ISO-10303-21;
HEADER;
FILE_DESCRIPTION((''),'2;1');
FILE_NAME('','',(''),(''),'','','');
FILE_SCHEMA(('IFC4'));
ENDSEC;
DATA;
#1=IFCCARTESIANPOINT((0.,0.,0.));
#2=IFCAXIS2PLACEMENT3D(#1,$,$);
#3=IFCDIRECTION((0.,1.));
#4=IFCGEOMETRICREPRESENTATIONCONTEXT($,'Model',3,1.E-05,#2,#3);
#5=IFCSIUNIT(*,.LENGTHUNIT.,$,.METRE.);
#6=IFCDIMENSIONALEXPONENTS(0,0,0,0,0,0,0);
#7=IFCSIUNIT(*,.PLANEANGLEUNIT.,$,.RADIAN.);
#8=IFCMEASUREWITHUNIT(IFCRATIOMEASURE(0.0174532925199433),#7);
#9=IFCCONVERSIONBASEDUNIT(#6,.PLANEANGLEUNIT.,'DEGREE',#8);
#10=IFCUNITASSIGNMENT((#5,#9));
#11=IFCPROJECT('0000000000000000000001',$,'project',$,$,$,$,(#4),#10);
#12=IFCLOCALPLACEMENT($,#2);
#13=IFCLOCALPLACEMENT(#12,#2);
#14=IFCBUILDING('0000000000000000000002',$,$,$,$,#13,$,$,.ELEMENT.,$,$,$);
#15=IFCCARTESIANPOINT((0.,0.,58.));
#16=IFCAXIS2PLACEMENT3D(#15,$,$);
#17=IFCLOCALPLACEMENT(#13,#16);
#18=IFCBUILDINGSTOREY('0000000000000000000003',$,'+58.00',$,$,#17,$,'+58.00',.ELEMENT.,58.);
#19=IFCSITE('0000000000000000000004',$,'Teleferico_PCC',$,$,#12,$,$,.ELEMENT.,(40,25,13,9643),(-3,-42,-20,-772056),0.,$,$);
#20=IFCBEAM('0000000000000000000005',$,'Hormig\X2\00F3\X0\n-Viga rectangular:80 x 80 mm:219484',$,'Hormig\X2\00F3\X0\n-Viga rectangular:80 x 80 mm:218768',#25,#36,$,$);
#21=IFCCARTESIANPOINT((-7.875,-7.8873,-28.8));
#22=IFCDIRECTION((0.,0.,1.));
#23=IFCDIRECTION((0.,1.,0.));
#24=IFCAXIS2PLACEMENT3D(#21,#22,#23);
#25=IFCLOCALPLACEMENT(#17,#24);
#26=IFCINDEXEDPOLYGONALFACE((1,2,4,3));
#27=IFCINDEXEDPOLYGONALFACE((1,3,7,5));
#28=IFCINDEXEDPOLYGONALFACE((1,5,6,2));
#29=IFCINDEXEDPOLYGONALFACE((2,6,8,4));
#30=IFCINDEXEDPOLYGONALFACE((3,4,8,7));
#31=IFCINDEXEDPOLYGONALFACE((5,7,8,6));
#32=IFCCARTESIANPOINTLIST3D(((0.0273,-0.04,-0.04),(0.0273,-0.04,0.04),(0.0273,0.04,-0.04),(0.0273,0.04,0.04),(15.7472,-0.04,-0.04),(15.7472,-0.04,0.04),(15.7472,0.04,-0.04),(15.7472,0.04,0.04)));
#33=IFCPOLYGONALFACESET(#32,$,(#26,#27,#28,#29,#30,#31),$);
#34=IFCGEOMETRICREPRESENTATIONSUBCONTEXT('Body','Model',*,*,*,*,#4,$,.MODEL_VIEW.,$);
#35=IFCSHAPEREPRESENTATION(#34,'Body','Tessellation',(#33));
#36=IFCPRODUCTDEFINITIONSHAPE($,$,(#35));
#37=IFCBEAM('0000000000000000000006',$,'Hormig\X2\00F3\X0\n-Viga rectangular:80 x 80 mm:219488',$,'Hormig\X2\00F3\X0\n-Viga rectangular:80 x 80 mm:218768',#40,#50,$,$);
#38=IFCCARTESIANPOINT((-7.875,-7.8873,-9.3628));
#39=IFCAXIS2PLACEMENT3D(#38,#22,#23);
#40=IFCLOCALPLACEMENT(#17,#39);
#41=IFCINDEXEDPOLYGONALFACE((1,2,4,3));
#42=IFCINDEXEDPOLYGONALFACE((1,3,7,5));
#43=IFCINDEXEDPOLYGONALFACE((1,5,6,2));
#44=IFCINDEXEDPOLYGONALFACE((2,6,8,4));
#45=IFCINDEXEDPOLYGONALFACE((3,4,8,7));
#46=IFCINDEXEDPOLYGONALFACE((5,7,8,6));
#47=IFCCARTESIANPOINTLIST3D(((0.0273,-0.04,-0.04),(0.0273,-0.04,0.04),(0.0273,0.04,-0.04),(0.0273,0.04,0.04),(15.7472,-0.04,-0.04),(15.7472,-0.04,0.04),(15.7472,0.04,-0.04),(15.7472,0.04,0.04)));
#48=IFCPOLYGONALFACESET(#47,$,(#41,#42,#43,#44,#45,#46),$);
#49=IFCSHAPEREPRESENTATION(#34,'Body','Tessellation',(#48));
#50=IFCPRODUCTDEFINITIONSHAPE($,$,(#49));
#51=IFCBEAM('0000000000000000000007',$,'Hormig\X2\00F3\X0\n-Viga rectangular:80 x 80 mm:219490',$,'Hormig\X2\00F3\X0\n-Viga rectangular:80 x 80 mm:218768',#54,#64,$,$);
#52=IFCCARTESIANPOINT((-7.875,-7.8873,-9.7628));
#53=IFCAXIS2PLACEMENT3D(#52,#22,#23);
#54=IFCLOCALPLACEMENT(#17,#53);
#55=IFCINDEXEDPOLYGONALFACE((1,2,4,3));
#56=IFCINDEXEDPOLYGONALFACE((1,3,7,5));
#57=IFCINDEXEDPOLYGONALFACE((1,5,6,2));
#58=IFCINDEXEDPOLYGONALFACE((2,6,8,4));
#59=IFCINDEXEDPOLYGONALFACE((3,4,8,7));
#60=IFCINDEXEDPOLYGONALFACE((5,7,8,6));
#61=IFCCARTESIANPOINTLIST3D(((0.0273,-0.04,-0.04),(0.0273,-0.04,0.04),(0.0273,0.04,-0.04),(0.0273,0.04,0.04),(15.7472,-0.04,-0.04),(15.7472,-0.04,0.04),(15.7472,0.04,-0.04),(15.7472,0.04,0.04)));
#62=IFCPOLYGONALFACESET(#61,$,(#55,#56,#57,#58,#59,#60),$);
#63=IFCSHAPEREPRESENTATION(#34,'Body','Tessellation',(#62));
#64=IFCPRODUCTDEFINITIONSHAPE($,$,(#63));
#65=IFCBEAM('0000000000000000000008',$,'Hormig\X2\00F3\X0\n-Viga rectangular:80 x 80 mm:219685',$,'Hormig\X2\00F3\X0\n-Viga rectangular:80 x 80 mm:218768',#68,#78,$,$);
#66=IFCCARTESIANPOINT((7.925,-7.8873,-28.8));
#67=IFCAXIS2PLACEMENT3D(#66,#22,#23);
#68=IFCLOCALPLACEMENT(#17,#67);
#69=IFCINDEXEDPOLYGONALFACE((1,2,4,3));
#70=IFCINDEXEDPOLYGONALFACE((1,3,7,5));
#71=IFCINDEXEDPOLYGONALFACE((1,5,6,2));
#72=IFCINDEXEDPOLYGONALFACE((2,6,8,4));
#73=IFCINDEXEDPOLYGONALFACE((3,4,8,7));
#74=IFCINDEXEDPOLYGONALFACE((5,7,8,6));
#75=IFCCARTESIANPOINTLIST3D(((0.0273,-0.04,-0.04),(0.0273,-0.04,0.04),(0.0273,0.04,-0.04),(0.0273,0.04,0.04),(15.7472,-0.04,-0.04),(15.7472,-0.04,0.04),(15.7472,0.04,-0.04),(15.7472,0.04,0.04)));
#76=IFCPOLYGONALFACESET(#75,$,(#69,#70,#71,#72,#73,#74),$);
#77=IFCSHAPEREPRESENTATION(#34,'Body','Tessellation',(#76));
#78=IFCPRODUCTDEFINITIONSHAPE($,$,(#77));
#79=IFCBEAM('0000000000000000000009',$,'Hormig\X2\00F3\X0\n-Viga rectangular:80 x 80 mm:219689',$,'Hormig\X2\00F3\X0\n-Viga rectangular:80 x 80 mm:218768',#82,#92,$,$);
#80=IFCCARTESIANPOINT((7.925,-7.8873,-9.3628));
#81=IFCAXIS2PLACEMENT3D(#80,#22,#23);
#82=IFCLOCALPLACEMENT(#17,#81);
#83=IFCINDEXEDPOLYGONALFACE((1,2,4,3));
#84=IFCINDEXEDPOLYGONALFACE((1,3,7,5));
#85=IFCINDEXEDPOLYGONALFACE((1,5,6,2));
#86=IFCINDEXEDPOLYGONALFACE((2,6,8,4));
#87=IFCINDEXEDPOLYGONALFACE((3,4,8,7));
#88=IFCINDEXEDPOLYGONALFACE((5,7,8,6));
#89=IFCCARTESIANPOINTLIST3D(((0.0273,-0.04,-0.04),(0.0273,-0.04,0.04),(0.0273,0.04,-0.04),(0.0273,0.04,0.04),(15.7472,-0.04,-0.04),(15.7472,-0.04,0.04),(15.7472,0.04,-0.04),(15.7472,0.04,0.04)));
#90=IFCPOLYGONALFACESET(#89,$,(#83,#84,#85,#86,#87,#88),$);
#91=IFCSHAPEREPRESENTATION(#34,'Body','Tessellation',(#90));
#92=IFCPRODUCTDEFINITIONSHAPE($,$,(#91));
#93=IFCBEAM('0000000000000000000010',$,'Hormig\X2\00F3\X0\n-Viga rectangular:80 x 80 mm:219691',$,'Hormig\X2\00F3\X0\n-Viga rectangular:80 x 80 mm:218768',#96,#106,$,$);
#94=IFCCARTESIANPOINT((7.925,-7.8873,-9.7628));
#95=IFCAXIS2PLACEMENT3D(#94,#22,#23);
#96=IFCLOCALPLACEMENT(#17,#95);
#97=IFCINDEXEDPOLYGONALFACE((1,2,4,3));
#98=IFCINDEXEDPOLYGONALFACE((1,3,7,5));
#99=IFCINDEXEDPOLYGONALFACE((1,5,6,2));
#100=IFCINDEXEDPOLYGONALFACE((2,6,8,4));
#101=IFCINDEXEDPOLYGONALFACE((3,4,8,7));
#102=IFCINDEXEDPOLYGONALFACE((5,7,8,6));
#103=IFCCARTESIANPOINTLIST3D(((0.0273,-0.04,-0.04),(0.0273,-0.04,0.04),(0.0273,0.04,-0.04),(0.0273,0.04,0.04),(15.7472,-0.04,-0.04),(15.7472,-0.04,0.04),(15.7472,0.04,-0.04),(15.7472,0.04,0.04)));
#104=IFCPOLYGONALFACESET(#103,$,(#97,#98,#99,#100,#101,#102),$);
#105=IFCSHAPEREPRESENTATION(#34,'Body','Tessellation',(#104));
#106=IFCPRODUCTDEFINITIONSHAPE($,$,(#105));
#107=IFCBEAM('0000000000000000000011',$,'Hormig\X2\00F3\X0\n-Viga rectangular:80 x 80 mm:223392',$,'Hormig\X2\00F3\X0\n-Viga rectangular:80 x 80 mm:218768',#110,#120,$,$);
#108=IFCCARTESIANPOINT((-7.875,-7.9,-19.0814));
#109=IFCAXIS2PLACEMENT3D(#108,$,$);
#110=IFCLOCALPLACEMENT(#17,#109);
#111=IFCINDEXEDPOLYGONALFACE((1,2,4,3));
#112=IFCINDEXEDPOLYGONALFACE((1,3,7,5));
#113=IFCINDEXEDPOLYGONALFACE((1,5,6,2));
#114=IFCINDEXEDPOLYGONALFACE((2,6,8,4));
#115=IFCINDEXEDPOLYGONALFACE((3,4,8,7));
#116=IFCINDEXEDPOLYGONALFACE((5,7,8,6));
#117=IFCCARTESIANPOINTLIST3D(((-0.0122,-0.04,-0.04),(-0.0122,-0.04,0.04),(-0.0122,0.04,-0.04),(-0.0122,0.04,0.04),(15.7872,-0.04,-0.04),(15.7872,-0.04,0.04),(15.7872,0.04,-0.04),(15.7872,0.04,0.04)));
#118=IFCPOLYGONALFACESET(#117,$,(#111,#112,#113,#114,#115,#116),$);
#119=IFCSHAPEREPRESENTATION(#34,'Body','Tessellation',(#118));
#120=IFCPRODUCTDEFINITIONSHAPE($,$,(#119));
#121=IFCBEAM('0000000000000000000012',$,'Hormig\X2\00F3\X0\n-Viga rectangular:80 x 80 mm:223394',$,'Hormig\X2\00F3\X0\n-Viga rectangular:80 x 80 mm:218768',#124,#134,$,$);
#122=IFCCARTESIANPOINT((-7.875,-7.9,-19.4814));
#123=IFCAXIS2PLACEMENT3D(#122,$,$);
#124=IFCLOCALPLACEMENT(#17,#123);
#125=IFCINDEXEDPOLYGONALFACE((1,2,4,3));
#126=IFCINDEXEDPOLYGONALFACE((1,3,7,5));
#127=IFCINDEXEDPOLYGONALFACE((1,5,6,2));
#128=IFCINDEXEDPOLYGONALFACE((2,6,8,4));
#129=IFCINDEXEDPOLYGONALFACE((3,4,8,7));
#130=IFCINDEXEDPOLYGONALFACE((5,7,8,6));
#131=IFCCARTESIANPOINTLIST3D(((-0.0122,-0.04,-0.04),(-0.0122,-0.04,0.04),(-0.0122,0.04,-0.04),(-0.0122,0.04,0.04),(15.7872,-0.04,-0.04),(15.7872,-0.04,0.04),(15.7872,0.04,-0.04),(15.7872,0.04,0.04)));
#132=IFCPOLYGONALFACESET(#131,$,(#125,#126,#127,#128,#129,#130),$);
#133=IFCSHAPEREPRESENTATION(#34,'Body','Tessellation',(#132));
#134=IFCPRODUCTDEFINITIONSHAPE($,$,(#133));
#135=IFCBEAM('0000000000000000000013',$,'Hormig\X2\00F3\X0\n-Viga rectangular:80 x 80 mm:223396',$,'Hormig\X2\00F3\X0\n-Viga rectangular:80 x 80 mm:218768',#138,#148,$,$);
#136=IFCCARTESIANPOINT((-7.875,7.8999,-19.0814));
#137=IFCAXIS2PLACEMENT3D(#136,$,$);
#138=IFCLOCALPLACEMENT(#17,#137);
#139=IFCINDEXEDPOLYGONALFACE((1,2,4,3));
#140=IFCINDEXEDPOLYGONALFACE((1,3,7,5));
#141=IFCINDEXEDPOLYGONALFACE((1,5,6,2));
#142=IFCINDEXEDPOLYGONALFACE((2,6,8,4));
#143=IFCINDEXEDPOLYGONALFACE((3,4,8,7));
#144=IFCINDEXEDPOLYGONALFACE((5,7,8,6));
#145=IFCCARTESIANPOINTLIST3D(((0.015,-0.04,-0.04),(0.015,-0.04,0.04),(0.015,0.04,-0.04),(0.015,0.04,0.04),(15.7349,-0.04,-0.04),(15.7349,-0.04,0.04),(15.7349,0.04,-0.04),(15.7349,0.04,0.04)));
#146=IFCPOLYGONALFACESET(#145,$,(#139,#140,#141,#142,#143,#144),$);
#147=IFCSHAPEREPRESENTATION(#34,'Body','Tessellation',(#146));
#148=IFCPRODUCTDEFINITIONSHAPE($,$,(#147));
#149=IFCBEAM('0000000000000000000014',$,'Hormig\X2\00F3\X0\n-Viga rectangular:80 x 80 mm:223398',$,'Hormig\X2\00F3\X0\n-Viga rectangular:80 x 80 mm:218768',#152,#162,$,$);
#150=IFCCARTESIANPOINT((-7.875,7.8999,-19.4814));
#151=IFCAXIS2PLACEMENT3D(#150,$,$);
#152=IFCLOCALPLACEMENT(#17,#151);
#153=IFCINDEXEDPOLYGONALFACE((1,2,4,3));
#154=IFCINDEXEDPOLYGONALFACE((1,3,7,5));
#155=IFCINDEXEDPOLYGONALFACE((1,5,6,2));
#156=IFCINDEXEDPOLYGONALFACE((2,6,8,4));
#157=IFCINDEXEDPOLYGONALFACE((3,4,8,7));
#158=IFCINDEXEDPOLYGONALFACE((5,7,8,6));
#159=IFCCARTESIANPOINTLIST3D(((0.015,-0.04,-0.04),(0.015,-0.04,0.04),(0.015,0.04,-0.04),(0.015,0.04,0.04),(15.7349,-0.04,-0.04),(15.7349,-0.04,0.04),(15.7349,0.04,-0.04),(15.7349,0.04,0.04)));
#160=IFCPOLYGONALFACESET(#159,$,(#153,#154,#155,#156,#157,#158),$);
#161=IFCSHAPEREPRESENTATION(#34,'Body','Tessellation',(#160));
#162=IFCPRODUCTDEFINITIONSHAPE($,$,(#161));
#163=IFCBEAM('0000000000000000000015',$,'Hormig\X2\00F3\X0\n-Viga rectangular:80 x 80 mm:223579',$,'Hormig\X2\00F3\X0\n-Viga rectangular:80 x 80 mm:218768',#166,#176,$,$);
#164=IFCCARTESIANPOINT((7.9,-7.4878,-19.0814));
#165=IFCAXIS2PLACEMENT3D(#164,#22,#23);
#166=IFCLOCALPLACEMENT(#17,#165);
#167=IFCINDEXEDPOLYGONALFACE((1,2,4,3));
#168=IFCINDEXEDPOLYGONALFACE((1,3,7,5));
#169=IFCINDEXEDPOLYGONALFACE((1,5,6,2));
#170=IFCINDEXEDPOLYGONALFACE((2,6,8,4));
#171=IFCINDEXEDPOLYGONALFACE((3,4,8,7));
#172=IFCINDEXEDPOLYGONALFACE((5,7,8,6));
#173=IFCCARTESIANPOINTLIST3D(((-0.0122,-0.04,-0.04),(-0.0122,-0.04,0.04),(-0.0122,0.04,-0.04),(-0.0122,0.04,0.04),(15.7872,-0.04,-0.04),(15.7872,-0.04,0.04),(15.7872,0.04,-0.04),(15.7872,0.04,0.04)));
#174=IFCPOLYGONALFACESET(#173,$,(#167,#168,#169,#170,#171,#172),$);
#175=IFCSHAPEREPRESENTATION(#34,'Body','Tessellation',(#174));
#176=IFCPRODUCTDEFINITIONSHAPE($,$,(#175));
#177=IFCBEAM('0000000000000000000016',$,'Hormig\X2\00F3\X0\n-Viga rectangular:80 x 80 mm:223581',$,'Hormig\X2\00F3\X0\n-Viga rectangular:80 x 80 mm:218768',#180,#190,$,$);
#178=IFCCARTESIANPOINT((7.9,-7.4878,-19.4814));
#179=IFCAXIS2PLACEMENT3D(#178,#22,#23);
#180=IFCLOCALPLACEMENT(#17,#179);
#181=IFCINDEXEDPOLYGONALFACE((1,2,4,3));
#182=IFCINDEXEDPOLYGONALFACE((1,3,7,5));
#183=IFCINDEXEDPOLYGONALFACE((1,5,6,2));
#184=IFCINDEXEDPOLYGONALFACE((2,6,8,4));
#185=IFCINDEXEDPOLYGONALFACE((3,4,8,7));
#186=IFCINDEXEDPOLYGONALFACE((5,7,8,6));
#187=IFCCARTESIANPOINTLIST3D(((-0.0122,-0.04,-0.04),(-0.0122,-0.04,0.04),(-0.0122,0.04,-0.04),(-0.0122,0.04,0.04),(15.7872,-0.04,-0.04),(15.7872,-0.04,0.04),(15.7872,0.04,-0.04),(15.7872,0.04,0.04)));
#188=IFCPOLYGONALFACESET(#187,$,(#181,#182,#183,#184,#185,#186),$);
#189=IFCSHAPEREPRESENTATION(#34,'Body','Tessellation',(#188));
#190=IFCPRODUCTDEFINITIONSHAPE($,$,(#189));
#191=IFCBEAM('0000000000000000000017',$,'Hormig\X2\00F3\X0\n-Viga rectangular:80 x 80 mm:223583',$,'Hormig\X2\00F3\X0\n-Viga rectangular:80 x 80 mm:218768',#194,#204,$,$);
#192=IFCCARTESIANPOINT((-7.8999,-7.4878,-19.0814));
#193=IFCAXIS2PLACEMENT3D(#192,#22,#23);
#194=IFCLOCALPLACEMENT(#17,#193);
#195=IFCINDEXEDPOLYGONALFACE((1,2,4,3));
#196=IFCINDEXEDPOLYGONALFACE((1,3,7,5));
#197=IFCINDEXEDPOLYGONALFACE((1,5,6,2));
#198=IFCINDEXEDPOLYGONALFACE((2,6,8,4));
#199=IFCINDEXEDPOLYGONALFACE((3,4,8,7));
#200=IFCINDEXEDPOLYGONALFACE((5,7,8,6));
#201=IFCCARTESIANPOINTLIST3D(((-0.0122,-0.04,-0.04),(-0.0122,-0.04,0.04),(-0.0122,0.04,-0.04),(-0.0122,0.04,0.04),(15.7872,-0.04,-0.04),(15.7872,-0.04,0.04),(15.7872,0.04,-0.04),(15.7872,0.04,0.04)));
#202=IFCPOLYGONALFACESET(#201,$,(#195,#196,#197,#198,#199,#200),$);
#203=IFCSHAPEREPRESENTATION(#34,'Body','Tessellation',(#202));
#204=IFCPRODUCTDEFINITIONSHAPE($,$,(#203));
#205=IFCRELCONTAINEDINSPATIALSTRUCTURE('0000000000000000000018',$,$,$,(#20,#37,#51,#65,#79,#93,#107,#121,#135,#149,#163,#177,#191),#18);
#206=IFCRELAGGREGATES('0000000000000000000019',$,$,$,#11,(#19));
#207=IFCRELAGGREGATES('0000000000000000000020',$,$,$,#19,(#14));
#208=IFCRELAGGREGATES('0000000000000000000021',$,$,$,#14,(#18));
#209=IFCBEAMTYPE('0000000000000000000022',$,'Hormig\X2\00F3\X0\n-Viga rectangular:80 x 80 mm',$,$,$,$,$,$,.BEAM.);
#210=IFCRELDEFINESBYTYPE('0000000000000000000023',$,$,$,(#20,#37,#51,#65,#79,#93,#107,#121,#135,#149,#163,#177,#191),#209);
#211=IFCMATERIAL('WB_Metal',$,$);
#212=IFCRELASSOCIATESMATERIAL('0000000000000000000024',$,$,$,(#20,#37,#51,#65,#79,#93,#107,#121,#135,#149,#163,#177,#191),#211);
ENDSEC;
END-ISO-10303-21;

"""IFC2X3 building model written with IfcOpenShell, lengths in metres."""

from ifc_helpers import new_model, entity, si_unit, converted_unit, direction, frame, frame_2d, origin, place, context, subcontext, project, spatial, rectangle, extrude, material, type_object, element, save


model = new_model("IFC2X3")

# Units and contexts
model_context = context("Model", 3, precision=1e-05, world=origin(), true_north=direction((0.0, 1.0)))
body_context = subcontext(model_context, "Body", "Model", "MODEL_VIEW")
ifc_project = project(units=[si_unit("LENGTHUNIT", "METRE"), converted_unit("PLANEANGLEUNIT", "DEGREE", entity("IfcRatioMeasure", 0.0174532925199433), si_unit("PLANEANGLEUNIT", "RADIAN"), dimensions=[0, 0, 0, 0, 0, 0, 0])], contexts=[model_context])

# Site, building, storey
site_placement = place(None, origin())
site = spatial("IfcSite", under=ifc_project, at=site_placement, Name="Teleferico_PCC", CompositionType="ELEMENT", RefLatitude=(40, 25, 13, 9643), RefLongitude=(-3, -42, -20, -772056), RefElevation=0.0)
building_placement = place(site_placement, origin())
building = spatial("IfcBuilding", under=site, at=building_placement, CompositionType="ELEMENT")
storey_placement = place(building_placement, frame((0.0, 0.0, 58.0)))
storey = spatial("IfcBuildingStorey", under=building, at=storey_placement, Name="+58.00", LongName="+58.00", CompositionType="ELEMENT", Elevation=58.0)

# Beams
ifc_material = material(Name="WB_Metal")
beam_type_1 = type_object("IfcBeamType", Name="Hormigón-Viga rectangular:80 x 80 mm", PredefinedType="BEAM")
beam_1_placement = place(storey_placement, frame((-7.875, -7.8873, -28.8), z_axis=(0.0, 0.0, 1.0), x_axis=(0.0, 1.0, 0.0)))
element("IfcBeam", 1, at=beam_1_placement, inside=storey, type_object=beam_type_1, material=ifc_material, Name="Hormigón-Viga rectangular:80 x 80 mm:219484", ObjectType="Hormigón-Viga rectangular:80 x 80 mm:218768", context=body_context, shape_type="SweptSolid", body=[
    extrude(rectangle(XDim=0.08, YDim=0.08, at=frame_2d((0.0, 0.0), x_axis=(1.0, 0.0))), frame((0.0273, 0.0, 0.0), z_axis=(1.0, 0.0, 0.0), x_axis=(0.0, 0.0, -1.0)), (0.0, 0.0, 1.0), 15.7199),
])
beam_2_placement = place(storey_placement, frame((-7.875, -7.8873, -9.3628), z_axis=(0.0, 0.0, 1.0), x_axis=(0.0, 1.0, 0.0)))
element("IfcBeam", 2, at=beam_2_placement, inside=storey, type_object=beam_type_1, material=ifc_material, Name="Hormigón-Viga rectangular:80 x 80 mm:219488", ObjectType="Hormigón-Viga rectangular:80 x 80 mm:218768", context=body_context, shape_type="SweptSolid", body=[
    extrude(rectangle(XDim=0.08, YDim=0.08, at=frame_2d((0.0, 0.0), x_axis=(1.0, 0.0))), frame((0.0273, 0.0, 0.0), z_axis=(1.0, 0.0, 0.0), x_axis=(0.0, 0.0, -1.0)), (0.0, 0.0, 1.0), 15.7199),
])
beam_3_placement = place(storey_placement, frame((-7.875, -7.8873, -9.7628), z_axis=(0.0, 0.0, 1.0), x_axis=(0.0, 1.0, 0.0)))
element("IfcBeam", 3, at=beam_3_placement, inside=storey, type_object=beam_type_1, material=ifc_material, Name="Hormigón-Viga rectangular:80 x 80 mm:219490", ObjectType="Hormigón-Viga rectangular:80 x 80 mm:218768", context=body_context, shape_type="SweptSolid", body=[
    extrude(rectangle(XDim=0.08, YDim=0.08, at=frame_2d((0.0, 0.0), x_axis=(1.0, 0.0))), frame((0.0273, 0.0, 0.0), z_axis=(1.0, 0.0, 0.0), x_axis=(0.0, 0.0, -1.0)), (0.0, 0.0, 1.0), 15.7199),
])
beam_4_placement = place(storey_placement, frame((7.925, -7.8873, -28.8), z_axis=(0.0, 0.0, 1.0), x_axis=(0.0, 1.0, 0.0)))
element("IfcBeam", 4, at=beam_4_placement, inside=storey, type_object=beam_type_1, material=ifc_material, Name="Hormigón-Viga rectangular:80 x 80 mm:219685", ObjectType="Hormigón-Viga rectangular:80 x 80 mm:218768", context=body_context, shape_type="SweptSolid", body=[
    extrude(rectangle(XDim=0.08, YDim=0.08, at=frame_2d((0.0, 0.0), x_axis=(1.0, 0.0))), frame((0.0273, 0.0, 0.0), z_axis=(1.0, 0.0, 0.0), x_axis=(0.0, 0.0, -1.0)), (0.0, 0.0, 1.0), 15.7199),
])
beam_5_placement = place(storey_placement, frame((7.925, -7.8873, -9.3628), z_axis=(0.0, 0.0, 1.0), x_axis=(0.0, 1.0, 0.0)))
element("IfcBeam", 5, at=beam_5_placement, inside=storey, type_object=beam_type_1, material=ifc_material, Name="Hormigón-Viga rectangular:80 x 80 mm:219689", ObjectType="Hormigón-Viga rectangular:80 x 80 mm:218768", context=body_context, shape_type="SweptSolid", body=[
    extrude(rectangle(XDim=0.08, YDim=0.08, at=frame_2d((0.0, 0.0), x_axis=(1.0, 0.0))), frame((0.0273, 0.0, 0.0), z_axis=(1.0, 0.0, 0.0), x_axis=(0.0, 0.0, -1.0)), (0.0, 0.0, 1.0), 15.7199),
])
beam_6_placement = place(storey_placement, frame((7.925, -7.8873, -9.7628), z_axis=(0.0, 0.0, 1.0), x_axis=(0.0, 1.0, 0.0)))
element("IfcBeam", 6, at=beam_6_placement, inside=storey, type_object=beam_type_1, material=ifc_material, Name="Hormigón-Viga rectangular:80 x 80 mm:219691", ObjectType="Hormigón-Viga rectangular:80 x 80 mm:218768", context=body_context, shape_type="SweptSolid", body=[
    extrude(rectangle(XDim=0.08, YDim=0.08, at=frame_2d((0.0, 0.0), x_axis=(1.0, 0.0))), frame((0.0273, 0.0, 0.0), z_axis=(1.0, 0.0, 0.0), x_axis=(0.0, 0.0, -1.0)), (0.0, 0.0, 1.0), 15.7199),
])
beam_7_placement = place(storey_placement, frame((-7.875, -7.9, -19.0814)))
element("IfcBeam", 7, at=beam_7_placement, inside=storey, type_object=beam_type_1, material=ifc_material, Name="Hormigón-Viga rectangular:80 x 80 mm:223392", ObjectType="Hormigón-Viga rectangular:80 x 80 mm:218768", context=body_context, shape_type="SweptSolid", body=[
    extrude(rectangle(XDim=0.08, YDim=0.08, at=frame_2d((0.0, 0.0), x_axis=(1.0, 0.0))), frame((-0.0122, 0.0, 0.0), z_axis=(1.0, 0.0, 0.0), x_axis=(0.0, 0.0, -1.0)), (0.0, 0.0, 1.0), 15.7994),
])
beam_8_placement = place(storey_placement, frame((-7.875, -7.9, -19.4814)))
element("IfcBeam", 8, at=beam_8_placement, inside=storey, type_object=beam_type_1, material=ifc_material, Name="Hormigón-Viga rectangular:80 x 80 mm:223394", ObjectType="Hormigón-Viga rectangular:80 x 80 mm:218768", context=body_context, shape_type="SweptSolid", body=[
    extrude(rectangle(XDim=0.08, YDim=0.08, at=frame_2d((0.0, 0.0), x_axis=(1.0, 0.0))), frame((-0.0122, 0.0, 0.0), z_axis=(1.0, 0.0, 0.0), x_axis=(0.0, 0.0, -1.0)), (0.0, 0.0, 1.0), 15.7994),
])
beam_9_placement = place(storey_placement, frame((-7.875, 7.8999, -19.0814)))
element("IfcBeam", 9, at=beam_9_placement, inside=storey, type_object=beam_type_1, material=ifc_material, Name="Hormigón-Viga rectangular:80 x 80 mm:223396", ObjectType="Hormigón-Viga rectangular:80 x 80 mm:218768", context=body_context, shape_type="SweptSolid", body=[
    extrude(rectangle(XDim=0.08, YDim=0.08, at=frame_2d((0.0, 0.0), x_axis=(1.0, 0.0))), frame((0.015, 0.0, 0.0), z_axis=(1.0, 0.0, 0.0), x_axis=(0.0, 0.0, -1.0)), (0.0, 0.0, 1.0), 15.7199),
])
beam_10_placement = place(storey_placement, frame((-7.875, 7.8999, -19.4814)))
element("IfcBeam", 10, at=beam_10_placement, inside=storey, type_object=beam_type_1, material=ifc_material, Name="Hormigón-Viga rectangular:80 x 80 mm:223398", ObjectType="Hormigón-Viga rectangular:80 x 80 mm:218768", context=body_context, shape_type="SweptSolid", body=[
    extrude(rectangle(XDim=0.08, YDim=0.08, at=frame_2d((0.0, 0.0), x_axis=(1.0, 0.0))), frame((0.015, 0.0, 0.0), z_axis=(1.0, 0.0, 0.0), x_axis=(0.0, 0.0, -1.0)), (0.0, 0.0, 1.0), 15.7199),
])
beam_11_placement = place(storey_placement, frame((7.9, -7.4878, -19.0814), z_axis=(0.0, 0.0, 1.0), x_axis=(0.0, 1.0, 0.0)))
element("IfcBeam", 11, at=beam_11_placement, inside=storey, type_object=beam_type_1, material=ifc_material, Name="Hormigón-Viga rectangular:80 x 80 mm:223579", ObjectType="Hormigón-Viga rectangular:80 x 80 mm:218768", context=body_context, shape_type="SweptSolid", body=[
    extrude(rectangle(XDim=0.08, YDim=0.08, at=frame_2d((0.0, 0.0), x_axis=(1.0, 0.0))), frame((-0.0122, 0.0, 0.0), z_axis=(1.0, 0.0, 0.0), x_axis=(0.0, 0.0, -1.0)), (0.0, 0.0, 1.0), 15.7994),
])
beam_12_placement = place(storey_placement, frame((7.9, -7.4878, -19.4814), z_axis=(0.0, 0.0, 1.0), x_axis=(0.0, 1.0, 0.0)))
element("IfcBeam", 12, at=beam_12_placement, inside=storey, type_object=beam_type_1, material=ifc_material, Name="Hormigón-Viga rectangular:80 x 80 mm:223581", ObjectType="Hormigón-Viga rectangular:80 x 80 mm:218768", context=body_context, shape_type="SweptSolid", body=[
    extrude(rectangle(XDim=0.08, YDim=0.08, at=frame_2d((0.0, 0.0), x_axis=(1.0, 0.0))), frame((-0.0122, 0.0, 0.0), z_axis=(1.0, 0.0, 0.0), x_axis=(0.0, 0.0, -1.0)), (0.0, 0.0, 1.0), 15.7994),
])
beam_13_placement = place(storey_placement, frame((-7.8999, -7.4878, -19.0814), z_axis=(0.0, 0.0, 1.0), x_axis=(0.0, 1.0, 0.0)))
element("IfcBeam", 13, at=beam_13_placement, inside=storey, type_object=beam_type_1, material=ifc_material, Name="Hormigón-Viga rectangular:80 x 80 mm:223583", ObjectType="Hormigón-Viga rectangular:80 x 80 mm:218768", context=body_context, shape_type="SweptSolid", body=[
    extrude(rectangle(XDim=0.08, YDim=0.08, at=frame_2d((0.0, 0.0), x_axis=(1.0, 0.0))), frame((-0.0122, 0.0, 0.0), z_axis=(1.0, 0.0, 0.0), x_axis=(0.0, 0.0, -1.0)), (0.0, 0.0, 1.0), 15.7994),
])

save(model, "model.ifc")
